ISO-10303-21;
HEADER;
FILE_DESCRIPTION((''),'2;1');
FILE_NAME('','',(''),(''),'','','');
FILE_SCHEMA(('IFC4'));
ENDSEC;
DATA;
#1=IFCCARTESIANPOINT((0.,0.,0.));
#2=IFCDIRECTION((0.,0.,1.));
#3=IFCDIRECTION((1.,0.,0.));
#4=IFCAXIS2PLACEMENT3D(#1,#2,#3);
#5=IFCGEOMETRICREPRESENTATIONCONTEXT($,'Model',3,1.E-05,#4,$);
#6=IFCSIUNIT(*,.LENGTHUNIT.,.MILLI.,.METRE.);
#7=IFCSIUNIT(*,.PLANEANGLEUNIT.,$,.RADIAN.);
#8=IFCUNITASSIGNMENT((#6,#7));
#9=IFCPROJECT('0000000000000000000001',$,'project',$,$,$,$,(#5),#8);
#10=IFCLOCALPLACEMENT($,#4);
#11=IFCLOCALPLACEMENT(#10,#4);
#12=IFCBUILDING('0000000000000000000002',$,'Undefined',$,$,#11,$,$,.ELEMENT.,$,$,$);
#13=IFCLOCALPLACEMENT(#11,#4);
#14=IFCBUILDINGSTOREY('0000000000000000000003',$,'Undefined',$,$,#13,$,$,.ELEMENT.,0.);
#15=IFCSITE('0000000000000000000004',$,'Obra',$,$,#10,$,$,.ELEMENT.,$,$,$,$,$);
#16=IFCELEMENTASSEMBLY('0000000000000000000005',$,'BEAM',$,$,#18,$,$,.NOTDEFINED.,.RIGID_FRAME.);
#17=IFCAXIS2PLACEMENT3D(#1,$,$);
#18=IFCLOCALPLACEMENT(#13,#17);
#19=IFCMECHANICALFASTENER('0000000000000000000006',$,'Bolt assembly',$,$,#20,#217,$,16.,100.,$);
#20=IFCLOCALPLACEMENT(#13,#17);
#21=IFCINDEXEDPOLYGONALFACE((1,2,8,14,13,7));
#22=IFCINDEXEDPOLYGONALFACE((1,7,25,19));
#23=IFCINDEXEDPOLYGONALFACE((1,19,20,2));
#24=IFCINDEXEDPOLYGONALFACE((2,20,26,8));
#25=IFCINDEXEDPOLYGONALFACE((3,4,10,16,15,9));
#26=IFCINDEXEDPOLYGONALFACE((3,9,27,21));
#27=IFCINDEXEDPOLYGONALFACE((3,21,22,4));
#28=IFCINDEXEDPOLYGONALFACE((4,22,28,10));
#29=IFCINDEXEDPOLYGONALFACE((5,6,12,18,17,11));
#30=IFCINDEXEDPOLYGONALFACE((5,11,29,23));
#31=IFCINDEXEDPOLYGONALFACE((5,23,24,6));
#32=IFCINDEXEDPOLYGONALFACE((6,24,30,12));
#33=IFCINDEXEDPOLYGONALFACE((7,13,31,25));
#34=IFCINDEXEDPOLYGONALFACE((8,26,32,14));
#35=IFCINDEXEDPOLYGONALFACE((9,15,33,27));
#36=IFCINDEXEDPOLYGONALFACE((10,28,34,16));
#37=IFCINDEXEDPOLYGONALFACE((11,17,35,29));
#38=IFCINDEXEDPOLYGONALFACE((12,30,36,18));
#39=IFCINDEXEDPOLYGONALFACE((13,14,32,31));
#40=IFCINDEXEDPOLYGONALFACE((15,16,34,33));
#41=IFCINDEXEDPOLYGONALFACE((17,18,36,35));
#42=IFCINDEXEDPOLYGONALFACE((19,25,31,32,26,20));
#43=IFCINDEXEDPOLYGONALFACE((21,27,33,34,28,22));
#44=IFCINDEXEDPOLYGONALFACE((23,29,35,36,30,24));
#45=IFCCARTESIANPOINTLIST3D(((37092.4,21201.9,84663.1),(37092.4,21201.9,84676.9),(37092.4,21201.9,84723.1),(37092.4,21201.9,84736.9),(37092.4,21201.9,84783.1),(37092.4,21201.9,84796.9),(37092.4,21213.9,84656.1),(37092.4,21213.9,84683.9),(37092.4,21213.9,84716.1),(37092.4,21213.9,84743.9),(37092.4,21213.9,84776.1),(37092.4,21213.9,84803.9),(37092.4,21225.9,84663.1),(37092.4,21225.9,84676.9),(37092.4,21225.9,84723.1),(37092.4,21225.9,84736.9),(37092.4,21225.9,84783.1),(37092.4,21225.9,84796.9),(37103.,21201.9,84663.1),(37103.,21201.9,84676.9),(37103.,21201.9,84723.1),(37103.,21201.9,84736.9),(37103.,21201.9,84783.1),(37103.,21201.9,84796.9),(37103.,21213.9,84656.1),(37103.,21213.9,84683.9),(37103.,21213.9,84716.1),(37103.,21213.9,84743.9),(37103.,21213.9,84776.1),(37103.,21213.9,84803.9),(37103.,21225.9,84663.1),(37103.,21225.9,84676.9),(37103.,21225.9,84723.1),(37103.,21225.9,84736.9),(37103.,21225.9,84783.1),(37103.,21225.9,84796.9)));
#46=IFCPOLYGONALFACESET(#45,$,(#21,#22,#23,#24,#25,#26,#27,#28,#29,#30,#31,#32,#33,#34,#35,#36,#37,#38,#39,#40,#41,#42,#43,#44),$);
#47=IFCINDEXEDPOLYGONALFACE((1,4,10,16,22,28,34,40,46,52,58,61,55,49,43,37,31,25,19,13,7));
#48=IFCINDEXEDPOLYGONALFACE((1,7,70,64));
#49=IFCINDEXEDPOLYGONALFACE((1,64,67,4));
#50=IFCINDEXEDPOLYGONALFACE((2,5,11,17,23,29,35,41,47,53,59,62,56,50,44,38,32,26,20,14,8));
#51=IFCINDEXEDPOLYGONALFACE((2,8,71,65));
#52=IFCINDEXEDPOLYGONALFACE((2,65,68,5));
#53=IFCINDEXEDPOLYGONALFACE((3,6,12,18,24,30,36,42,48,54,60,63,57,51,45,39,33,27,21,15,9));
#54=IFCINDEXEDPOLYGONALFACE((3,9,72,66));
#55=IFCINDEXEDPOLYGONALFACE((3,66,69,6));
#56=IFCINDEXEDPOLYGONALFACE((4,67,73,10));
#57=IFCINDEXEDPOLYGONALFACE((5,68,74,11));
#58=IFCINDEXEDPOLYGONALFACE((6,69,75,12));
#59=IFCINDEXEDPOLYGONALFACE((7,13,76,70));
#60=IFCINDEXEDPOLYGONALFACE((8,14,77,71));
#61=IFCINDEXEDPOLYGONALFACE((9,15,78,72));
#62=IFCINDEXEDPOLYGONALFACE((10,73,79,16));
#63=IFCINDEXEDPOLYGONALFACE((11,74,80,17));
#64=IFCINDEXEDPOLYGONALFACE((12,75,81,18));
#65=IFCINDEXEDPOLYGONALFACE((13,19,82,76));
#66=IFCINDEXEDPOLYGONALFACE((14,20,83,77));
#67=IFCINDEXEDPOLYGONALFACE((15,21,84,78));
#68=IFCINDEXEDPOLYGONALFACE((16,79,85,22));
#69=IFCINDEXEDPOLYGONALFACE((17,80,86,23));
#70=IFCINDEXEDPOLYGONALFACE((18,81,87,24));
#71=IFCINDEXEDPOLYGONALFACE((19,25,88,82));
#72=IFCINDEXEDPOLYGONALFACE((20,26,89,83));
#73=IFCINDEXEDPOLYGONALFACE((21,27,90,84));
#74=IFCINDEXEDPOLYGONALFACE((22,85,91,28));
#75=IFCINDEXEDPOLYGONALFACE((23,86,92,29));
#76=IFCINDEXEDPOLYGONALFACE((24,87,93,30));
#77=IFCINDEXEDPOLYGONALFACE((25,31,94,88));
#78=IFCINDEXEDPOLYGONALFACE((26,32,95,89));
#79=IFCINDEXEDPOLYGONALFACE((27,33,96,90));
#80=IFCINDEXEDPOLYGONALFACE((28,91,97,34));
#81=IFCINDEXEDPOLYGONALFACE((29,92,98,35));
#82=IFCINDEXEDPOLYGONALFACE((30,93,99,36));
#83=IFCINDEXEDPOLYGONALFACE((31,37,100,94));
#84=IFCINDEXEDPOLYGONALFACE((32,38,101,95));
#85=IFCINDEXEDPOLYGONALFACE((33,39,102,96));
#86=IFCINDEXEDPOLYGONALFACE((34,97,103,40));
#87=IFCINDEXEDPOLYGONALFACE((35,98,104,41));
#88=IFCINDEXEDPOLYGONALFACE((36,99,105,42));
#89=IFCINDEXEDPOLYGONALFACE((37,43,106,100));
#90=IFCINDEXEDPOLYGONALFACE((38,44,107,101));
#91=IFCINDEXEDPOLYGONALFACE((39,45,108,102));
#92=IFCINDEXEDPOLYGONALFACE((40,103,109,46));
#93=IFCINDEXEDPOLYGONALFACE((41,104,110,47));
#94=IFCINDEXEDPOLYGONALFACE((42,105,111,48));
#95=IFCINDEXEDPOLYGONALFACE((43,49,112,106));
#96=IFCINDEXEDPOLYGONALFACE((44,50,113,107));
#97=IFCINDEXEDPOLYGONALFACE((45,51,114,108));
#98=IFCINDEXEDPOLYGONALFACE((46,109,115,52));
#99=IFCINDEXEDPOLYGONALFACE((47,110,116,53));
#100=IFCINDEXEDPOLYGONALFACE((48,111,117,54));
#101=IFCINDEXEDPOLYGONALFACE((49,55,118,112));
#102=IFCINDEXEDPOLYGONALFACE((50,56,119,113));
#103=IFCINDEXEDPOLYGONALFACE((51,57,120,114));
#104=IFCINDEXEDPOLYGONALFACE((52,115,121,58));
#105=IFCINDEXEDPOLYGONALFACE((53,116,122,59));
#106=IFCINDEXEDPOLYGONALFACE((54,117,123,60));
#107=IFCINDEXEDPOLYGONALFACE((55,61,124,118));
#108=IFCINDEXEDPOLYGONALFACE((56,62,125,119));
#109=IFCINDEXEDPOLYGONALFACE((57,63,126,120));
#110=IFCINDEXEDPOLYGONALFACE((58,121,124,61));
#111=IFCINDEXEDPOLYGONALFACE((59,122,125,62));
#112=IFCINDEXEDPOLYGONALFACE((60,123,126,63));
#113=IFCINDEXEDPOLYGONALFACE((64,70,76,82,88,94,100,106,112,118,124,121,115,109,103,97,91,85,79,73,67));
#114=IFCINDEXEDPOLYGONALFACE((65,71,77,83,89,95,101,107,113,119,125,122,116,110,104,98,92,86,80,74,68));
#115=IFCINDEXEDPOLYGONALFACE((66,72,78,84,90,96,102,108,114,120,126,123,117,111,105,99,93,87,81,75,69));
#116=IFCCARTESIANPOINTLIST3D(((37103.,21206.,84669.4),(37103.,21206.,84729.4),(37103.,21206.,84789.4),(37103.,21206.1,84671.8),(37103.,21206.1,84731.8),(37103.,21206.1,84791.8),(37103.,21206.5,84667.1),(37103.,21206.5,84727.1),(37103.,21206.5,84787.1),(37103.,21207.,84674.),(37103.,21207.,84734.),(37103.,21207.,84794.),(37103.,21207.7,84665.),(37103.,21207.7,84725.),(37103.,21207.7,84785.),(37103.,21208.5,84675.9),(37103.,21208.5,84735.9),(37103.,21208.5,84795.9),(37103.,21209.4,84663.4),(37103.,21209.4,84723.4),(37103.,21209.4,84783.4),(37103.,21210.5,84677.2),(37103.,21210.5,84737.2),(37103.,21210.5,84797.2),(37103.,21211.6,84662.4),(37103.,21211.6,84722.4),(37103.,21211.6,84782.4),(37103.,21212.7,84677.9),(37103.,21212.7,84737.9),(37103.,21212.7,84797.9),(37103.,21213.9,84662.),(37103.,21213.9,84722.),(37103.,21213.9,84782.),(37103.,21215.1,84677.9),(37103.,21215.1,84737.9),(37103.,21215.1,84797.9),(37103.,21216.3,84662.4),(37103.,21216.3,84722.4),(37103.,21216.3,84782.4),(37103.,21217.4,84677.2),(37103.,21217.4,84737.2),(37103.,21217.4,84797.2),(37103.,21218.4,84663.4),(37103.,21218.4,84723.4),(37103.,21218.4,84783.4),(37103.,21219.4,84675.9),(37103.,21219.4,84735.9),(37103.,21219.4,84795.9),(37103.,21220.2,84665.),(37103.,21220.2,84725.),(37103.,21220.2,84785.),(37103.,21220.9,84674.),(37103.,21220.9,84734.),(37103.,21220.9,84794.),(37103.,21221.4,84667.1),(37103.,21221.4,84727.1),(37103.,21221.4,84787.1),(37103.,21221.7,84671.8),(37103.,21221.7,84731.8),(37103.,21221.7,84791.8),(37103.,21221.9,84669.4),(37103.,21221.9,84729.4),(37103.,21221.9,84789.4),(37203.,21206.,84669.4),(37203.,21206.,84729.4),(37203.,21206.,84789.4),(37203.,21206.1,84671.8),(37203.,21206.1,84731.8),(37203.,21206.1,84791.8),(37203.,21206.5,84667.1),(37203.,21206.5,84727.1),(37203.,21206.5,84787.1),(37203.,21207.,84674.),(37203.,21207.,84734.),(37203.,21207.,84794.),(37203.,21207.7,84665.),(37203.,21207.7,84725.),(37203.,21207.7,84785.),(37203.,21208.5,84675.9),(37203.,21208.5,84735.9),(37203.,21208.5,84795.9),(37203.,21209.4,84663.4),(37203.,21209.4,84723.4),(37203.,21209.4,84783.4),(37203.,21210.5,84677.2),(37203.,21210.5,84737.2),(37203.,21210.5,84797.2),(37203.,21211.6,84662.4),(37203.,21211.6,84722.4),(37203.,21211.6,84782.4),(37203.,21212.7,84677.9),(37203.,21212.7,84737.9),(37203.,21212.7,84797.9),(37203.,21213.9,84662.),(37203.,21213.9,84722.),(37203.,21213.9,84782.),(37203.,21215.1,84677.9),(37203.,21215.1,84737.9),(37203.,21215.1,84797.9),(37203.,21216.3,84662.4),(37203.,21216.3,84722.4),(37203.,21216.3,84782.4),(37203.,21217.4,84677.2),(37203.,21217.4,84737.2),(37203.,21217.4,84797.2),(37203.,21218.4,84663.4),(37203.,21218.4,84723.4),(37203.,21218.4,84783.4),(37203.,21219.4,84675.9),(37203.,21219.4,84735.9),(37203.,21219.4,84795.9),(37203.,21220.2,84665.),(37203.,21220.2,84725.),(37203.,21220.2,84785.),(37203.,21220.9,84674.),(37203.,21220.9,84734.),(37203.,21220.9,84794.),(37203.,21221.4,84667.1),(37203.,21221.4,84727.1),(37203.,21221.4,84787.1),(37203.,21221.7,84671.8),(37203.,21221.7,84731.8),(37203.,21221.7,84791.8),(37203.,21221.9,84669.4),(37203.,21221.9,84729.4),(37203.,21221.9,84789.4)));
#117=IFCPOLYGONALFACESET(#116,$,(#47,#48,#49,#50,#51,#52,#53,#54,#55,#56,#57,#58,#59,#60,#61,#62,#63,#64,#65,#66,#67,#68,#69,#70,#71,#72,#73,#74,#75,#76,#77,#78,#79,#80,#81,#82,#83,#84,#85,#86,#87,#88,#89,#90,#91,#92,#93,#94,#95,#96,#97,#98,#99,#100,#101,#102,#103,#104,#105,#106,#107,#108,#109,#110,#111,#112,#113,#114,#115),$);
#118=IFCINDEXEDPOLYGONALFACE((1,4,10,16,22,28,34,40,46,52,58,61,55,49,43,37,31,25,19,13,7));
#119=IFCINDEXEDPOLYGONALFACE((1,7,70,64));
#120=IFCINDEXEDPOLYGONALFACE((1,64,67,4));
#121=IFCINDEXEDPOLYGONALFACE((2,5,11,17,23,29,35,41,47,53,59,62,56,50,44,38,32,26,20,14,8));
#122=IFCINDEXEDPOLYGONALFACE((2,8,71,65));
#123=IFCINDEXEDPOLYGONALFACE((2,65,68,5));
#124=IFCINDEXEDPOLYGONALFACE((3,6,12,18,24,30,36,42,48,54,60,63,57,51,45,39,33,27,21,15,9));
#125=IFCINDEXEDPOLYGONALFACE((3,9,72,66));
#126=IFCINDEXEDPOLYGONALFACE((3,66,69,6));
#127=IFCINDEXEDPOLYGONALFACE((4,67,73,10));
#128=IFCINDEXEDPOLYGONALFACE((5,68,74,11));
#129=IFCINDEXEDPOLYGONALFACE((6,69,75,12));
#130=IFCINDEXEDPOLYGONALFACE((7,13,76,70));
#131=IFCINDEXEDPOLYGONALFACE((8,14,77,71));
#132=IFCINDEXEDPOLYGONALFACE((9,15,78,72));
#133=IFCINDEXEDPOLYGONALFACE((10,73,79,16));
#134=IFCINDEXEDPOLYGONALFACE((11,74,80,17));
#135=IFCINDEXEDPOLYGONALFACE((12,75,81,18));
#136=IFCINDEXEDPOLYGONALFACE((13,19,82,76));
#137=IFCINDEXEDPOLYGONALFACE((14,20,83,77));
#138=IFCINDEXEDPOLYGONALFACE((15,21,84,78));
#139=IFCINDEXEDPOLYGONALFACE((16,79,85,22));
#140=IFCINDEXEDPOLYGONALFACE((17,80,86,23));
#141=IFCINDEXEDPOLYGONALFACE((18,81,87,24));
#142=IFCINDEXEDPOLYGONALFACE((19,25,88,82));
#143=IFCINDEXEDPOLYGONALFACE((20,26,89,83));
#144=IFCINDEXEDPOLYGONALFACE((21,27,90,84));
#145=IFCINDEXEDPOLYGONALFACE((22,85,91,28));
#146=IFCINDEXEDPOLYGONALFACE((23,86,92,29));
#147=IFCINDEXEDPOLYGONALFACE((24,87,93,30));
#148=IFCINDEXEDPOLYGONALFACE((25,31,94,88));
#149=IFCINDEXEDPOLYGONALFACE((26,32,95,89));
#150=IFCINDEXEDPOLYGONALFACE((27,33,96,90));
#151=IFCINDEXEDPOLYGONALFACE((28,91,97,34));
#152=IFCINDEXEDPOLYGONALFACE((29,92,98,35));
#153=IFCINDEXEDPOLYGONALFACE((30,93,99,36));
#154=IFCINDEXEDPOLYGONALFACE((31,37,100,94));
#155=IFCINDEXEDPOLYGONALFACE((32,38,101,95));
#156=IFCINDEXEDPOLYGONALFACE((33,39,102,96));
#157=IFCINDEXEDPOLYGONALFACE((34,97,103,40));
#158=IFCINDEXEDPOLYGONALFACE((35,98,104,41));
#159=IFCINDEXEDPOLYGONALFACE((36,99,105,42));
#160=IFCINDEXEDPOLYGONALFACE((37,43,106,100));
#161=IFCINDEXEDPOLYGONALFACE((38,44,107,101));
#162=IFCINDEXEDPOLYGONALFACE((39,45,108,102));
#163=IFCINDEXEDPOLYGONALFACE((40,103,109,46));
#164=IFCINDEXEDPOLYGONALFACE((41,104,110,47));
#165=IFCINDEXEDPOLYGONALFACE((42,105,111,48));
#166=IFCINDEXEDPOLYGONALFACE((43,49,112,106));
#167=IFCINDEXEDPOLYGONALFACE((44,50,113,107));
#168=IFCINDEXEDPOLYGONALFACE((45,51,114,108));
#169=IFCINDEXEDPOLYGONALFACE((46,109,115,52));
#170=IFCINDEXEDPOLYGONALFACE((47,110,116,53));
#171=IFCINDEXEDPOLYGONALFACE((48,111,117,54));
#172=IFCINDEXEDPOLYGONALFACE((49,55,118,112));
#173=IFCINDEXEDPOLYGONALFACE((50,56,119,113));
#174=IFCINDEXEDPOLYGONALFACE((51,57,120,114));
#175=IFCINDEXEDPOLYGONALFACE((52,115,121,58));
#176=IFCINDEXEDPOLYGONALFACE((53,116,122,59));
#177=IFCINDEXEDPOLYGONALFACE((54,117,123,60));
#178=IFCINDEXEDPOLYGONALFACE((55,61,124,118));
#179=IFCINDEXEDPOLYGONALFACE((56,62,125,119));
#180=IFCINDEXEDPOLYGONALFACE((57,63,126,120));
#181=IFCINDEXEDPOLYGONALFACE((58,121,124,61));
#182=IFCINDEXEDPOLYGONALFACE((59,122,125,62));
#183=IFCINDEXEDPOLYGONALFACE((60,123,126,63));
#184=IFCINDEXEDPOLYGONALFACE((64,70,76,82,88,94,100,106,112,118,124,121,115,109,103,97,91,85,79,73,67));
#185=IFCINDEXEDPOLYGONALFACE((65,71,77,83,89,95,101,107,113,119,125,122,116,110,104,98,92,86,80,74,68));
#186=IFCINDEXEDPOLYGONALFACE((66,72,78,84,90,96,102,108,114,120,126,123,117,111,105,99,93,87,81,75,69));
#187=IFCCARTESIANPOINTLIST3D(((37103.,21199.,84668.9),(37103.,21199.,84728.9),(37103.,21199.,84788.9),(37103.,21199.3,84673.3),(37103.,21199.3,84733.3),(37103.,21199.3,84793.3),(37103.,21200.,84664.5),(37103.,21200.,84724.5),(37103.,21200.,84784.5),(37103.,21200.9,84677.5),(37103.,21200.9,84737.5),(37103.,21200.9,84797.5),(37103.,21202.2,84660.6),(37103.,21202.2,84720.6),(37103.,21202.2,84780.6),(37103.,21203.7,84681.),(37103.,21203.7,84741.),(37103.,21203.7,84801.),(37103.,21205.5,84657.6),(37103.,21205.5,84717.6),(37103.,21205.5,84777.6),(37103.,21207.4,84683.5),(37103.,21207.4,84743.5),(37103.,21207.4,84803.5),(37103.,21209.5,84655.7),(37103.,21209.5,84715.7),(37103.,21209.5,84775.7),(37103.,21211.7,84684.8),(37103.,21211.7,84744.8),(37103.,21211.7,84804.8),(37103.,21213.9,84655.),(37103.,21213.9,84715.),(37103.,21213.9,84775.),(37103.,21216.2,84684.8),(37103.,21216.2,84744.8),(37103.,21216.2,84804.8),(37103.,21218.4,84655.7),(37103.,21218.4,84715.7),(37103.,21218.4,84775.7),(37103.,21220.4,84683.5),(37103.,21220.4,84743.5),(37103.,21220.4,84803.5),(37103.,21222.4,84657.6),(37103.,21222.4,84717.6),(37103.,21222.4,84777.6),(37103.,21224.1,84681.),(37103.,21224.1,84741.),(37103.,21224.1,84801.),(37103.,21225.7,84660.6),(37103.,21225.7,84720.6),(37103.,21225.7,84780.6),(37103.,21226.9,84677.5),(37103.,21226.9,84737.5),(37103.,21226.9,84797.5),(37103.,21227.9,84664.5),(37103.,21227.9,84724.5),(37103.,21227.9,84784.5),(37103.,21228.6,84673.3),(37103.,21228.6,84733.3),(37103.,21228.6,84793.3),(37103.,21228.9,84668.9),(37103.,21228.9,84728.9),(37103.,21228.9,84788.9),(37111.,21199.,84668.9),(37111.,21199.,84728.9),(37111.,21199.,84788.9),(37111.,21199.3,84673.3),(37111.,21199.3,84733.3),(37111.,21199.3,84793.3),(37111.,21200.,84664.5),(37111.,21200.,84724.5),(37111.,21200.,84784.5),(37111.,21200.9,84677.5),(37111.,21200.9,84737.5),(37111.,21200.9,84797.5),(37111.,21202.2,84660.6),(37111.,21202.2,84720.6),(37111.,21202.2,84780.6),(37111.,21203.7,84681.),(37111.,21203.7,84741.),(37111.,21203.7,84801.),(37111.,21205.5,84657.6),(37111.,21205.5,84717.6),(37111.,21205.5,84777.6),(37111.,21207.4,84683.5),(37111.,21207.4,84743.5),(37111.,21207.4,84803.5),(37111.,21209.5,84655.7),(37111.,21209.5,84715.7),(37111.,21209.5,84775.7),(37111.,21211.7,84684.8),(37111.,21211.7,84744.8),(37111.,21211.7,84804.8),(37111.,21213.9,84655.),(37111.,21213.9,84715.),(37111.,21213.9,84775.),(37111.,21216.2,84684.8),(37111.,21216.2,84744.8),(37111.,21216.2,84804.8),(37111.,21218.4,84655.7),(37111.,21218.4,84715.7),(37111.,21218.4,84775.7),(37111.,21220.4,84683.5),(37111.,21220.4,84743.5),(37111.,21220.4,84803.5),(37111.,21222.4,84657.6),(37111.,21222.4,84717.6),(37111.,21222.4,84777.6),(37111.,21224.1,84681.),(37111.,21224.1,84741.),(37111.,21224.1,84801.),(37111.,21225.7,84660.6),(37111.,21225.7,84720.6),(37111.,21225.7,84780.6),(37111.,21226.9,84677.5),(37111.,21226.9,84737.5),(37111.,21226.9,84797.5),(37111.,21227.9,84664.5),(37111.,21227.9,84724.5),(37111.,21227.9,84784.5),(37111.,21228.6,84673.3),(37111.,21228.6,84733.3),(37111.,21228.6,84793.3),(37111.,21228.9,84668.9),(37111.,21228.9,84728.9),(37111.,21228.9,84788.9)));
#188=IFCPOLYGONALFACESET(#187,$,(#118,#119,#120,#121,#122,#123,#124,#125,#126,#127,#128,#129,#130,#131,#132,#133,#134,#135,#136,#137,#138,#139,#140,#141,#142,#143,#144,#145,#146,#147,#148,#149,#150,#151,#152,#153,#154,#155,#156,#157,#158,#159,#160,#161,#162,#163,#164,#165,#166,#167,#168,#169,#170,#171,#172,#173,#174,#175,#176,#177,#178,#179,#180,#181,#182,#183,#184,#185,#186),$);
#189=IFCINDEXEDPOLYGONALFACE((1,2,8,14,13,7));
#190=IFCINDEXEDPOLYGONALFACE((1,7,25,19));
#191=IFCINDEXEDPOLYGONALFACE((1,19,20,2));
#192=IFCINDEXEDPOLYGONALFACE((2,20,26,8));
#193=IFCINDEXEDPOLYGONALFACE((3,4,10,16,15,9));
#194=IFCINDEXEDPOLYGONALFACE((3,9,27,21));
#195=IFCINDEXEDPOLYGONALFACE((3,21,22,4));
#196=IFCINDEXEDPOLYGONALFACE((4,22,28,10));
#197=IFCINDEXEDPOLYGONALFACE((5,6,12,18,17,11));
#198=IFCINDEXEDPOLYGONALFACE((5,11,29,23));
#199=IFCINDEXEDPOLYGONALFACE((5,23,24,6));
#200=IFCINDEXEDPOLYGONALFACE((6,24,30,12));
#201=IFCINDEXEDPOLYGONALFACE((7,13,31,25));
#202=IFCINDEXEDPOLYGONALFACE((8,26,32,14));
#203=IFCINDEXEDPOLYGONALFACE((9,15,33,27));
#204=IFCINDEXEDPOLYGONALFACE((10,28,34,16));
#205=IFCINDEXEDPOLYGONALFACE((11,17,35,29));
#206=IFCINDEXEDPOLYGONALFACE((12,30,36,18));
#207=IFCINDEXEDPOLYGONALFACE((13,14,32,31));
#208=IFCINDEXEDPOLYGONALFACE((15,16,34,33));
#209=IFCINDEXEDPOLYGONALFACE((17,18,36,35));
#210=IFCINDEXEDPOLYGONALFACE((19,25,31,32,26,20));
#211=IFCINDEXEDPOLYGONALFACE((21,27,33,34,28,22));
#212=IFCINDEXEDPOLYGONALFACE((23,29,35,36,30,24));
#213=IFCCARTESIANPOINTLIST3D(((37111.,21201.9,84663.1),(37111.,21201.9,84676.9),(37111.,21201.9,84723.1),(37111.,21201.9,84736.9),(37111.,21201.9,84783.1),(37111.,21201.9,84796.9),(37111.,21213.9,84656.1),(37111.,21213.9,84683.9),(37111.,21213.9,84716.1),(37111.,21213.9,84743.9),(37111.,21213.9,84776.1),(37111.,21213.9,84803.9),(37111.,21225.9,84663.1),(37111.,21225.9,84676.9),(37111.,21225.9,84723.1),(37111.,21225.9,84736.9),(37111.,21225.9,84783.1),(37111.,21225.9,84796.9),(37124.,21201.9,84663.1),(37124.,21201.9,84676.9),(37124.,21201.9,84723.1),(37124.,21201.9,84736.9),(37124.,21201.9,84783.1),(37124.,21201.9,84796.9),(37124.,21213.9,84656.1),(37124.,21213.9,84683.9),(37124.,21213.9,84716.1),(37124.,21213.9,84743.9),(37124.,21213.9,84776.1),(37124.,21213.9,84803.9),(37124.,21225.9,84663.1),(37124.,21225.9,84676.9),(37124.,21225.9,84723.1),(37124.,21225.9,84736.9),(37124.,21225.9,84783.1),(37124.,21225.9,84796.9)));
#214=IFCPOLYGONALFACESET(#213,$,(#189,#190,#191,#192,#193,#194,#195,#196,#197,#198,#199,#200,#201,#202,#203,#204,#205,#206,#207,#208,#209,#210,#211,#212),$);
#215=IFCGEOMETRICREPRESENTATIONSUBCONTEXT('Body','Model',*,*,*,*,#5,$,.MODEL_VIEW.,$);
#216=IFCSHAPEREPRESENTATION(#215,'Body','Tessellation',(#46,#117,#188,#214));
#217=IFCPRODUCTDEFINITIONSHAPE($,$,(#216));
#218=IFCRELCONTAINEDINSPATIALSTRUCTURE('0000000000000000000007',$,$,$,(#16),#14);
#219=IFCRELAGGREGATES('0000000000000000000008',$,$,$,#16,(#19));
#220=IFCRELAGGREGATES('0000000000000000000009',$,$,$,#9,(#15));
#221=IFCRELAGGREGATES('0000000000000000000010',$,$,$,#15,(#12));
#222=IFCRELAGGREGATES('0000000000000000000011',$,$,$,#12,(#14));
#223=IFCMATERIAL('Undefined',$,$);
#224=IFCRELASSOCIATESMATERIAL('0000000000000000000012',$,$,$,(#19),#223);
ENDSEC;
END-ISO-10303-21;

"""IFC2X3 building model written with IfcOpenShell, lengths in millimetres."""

from ifc_helpers import new_model, si_unit, frame, origin_with_axes, origin_2d_with_axis, place, context, subcontext, project, spatial, polyline, circle, outline, extrude, source, transform, mapped, material, element, aggregate, save


model = new_model("IFC2X3")

# Units and contexts
model_context = context("Model", 3, precision=1e-05, world=origin_with_axes())
body_context = subcontext(model_context, "Body", "Model", "MODEL_VIEW")
ifc_project = project(units=[si_unit("LENGTHUNIT", "METRE", prefix="MILLI"), si_unit("PLANEANGLEUNIT", "RADIAN")], contexts=[model_context])

# Site, building, storey
site_placement = place(None, origin_with_axes())
site = spatial("IfcSite", under=ifc_project, at=site_placement, Name="Obra", CompositionType="ELEMENT")
building_placement = place(site_placement, origin_with_axes())
building = spatial("IfcBuilding", under=site, at=building_placement, Name="Undefined", CompositionType="ELEMENT")
storey_placement = place(building_placement, origin_with_axes())
storey = spatial("IfcBuildingStorey", under=building, at=storey_placement, Name="Undefined", CompositionType="ELEMENT", Elevation=0.0)

# Shared definitions
ifc_material_1 = material(Name="Undefined")

# Element assembly, mechanical fastener
assembly_1_placement = place(storey_placement, origin_with_axes())
assembly_1 = element("IfcElementAssembly", 1, at=assembly_1_placement, inside=storey, Name="BEAM", AssemblyPlace="NOTDEFINED", PredefinedType="RIGID_FRAME")
shared_shape_1 = source(origin_with_axes(), body_context, "Body", "SweptSolid", [
    extrude(outline(polyline([(13.9, 0.0), (6.9, 12.0), (-6.9, 12.0), (-13.9, 0.0), (-6.9, -12.0), (6.9, -12.0), (13.9, 0.0)])), frame((0.0, -10.6, 0.0), z_axis=(0.0, 1.0, 0.0), x_axis=(1.0, 0.0, 0.0)), (0.0, 0.0, 1.0), 10.6),
    extrude(circle(Radius=8.0, at=origin_2d_with_axis()), frame((0.0, 0.0, 0.0), z_axis=(0.0, 1.0, 0.0), x_axis=(1.0, 0.0, 0.0)), (0.0, 0.0, 1.0), 100.0),
    extrude(circle(Radius=15.0, at=origin_2d_with_axis()), frame((0.0, 0.0, 0.0), z_axis=(0.0, 1.0, 0.0), x_axis=(1.0, 0.0, 0.0)), (0.0, 0.0, 1.0), 8.0),
    extrude(outline(polyline([(13.9, 0.0), (6.9, 12.0), (-6.9, 12.0), (-13.9, 0.0), (-6.9, -12.0), (6.9, -12.0), (13.9, 0.0)])), frame((0.0, 8.0, 0.0), z_axis=(0.0, 1.0, 0.0), x_axis=(1.0, 0.0, 0.0)), (0.0, 0.0, 1.0), 13.0),
])
mechanical_fastener_1_placement = place(assembly_1_placement, frame((37103.0, 21263.9, 84850.0), z_axis=(0.0, -1.0, 0.0), x_axis=(0.0, 0.0, -1.0)))
mechanical_fastener_1 = element("IfcMechanicalFastener", 2, at=mechanical_fastener_1_placement, material=ifc_material_1, Name="Bolt assembly", NominalDiameter=16.0, NominalLength=100.0, context=body_context, shape_type="MappedRepresentation", body=[
    mapped(shared_shape_1, transform((60.0, 0.0, 50.0))),
    mapped(shared_shape_1, transform((120.0, 0.0, 50.0))),
    mapped(shared_shape_1, transform((180.0, 0.0, 50.0))),
])
aggregate(assembly_1, [mechanical_fastener_1])

save(model, "model.ifc")
